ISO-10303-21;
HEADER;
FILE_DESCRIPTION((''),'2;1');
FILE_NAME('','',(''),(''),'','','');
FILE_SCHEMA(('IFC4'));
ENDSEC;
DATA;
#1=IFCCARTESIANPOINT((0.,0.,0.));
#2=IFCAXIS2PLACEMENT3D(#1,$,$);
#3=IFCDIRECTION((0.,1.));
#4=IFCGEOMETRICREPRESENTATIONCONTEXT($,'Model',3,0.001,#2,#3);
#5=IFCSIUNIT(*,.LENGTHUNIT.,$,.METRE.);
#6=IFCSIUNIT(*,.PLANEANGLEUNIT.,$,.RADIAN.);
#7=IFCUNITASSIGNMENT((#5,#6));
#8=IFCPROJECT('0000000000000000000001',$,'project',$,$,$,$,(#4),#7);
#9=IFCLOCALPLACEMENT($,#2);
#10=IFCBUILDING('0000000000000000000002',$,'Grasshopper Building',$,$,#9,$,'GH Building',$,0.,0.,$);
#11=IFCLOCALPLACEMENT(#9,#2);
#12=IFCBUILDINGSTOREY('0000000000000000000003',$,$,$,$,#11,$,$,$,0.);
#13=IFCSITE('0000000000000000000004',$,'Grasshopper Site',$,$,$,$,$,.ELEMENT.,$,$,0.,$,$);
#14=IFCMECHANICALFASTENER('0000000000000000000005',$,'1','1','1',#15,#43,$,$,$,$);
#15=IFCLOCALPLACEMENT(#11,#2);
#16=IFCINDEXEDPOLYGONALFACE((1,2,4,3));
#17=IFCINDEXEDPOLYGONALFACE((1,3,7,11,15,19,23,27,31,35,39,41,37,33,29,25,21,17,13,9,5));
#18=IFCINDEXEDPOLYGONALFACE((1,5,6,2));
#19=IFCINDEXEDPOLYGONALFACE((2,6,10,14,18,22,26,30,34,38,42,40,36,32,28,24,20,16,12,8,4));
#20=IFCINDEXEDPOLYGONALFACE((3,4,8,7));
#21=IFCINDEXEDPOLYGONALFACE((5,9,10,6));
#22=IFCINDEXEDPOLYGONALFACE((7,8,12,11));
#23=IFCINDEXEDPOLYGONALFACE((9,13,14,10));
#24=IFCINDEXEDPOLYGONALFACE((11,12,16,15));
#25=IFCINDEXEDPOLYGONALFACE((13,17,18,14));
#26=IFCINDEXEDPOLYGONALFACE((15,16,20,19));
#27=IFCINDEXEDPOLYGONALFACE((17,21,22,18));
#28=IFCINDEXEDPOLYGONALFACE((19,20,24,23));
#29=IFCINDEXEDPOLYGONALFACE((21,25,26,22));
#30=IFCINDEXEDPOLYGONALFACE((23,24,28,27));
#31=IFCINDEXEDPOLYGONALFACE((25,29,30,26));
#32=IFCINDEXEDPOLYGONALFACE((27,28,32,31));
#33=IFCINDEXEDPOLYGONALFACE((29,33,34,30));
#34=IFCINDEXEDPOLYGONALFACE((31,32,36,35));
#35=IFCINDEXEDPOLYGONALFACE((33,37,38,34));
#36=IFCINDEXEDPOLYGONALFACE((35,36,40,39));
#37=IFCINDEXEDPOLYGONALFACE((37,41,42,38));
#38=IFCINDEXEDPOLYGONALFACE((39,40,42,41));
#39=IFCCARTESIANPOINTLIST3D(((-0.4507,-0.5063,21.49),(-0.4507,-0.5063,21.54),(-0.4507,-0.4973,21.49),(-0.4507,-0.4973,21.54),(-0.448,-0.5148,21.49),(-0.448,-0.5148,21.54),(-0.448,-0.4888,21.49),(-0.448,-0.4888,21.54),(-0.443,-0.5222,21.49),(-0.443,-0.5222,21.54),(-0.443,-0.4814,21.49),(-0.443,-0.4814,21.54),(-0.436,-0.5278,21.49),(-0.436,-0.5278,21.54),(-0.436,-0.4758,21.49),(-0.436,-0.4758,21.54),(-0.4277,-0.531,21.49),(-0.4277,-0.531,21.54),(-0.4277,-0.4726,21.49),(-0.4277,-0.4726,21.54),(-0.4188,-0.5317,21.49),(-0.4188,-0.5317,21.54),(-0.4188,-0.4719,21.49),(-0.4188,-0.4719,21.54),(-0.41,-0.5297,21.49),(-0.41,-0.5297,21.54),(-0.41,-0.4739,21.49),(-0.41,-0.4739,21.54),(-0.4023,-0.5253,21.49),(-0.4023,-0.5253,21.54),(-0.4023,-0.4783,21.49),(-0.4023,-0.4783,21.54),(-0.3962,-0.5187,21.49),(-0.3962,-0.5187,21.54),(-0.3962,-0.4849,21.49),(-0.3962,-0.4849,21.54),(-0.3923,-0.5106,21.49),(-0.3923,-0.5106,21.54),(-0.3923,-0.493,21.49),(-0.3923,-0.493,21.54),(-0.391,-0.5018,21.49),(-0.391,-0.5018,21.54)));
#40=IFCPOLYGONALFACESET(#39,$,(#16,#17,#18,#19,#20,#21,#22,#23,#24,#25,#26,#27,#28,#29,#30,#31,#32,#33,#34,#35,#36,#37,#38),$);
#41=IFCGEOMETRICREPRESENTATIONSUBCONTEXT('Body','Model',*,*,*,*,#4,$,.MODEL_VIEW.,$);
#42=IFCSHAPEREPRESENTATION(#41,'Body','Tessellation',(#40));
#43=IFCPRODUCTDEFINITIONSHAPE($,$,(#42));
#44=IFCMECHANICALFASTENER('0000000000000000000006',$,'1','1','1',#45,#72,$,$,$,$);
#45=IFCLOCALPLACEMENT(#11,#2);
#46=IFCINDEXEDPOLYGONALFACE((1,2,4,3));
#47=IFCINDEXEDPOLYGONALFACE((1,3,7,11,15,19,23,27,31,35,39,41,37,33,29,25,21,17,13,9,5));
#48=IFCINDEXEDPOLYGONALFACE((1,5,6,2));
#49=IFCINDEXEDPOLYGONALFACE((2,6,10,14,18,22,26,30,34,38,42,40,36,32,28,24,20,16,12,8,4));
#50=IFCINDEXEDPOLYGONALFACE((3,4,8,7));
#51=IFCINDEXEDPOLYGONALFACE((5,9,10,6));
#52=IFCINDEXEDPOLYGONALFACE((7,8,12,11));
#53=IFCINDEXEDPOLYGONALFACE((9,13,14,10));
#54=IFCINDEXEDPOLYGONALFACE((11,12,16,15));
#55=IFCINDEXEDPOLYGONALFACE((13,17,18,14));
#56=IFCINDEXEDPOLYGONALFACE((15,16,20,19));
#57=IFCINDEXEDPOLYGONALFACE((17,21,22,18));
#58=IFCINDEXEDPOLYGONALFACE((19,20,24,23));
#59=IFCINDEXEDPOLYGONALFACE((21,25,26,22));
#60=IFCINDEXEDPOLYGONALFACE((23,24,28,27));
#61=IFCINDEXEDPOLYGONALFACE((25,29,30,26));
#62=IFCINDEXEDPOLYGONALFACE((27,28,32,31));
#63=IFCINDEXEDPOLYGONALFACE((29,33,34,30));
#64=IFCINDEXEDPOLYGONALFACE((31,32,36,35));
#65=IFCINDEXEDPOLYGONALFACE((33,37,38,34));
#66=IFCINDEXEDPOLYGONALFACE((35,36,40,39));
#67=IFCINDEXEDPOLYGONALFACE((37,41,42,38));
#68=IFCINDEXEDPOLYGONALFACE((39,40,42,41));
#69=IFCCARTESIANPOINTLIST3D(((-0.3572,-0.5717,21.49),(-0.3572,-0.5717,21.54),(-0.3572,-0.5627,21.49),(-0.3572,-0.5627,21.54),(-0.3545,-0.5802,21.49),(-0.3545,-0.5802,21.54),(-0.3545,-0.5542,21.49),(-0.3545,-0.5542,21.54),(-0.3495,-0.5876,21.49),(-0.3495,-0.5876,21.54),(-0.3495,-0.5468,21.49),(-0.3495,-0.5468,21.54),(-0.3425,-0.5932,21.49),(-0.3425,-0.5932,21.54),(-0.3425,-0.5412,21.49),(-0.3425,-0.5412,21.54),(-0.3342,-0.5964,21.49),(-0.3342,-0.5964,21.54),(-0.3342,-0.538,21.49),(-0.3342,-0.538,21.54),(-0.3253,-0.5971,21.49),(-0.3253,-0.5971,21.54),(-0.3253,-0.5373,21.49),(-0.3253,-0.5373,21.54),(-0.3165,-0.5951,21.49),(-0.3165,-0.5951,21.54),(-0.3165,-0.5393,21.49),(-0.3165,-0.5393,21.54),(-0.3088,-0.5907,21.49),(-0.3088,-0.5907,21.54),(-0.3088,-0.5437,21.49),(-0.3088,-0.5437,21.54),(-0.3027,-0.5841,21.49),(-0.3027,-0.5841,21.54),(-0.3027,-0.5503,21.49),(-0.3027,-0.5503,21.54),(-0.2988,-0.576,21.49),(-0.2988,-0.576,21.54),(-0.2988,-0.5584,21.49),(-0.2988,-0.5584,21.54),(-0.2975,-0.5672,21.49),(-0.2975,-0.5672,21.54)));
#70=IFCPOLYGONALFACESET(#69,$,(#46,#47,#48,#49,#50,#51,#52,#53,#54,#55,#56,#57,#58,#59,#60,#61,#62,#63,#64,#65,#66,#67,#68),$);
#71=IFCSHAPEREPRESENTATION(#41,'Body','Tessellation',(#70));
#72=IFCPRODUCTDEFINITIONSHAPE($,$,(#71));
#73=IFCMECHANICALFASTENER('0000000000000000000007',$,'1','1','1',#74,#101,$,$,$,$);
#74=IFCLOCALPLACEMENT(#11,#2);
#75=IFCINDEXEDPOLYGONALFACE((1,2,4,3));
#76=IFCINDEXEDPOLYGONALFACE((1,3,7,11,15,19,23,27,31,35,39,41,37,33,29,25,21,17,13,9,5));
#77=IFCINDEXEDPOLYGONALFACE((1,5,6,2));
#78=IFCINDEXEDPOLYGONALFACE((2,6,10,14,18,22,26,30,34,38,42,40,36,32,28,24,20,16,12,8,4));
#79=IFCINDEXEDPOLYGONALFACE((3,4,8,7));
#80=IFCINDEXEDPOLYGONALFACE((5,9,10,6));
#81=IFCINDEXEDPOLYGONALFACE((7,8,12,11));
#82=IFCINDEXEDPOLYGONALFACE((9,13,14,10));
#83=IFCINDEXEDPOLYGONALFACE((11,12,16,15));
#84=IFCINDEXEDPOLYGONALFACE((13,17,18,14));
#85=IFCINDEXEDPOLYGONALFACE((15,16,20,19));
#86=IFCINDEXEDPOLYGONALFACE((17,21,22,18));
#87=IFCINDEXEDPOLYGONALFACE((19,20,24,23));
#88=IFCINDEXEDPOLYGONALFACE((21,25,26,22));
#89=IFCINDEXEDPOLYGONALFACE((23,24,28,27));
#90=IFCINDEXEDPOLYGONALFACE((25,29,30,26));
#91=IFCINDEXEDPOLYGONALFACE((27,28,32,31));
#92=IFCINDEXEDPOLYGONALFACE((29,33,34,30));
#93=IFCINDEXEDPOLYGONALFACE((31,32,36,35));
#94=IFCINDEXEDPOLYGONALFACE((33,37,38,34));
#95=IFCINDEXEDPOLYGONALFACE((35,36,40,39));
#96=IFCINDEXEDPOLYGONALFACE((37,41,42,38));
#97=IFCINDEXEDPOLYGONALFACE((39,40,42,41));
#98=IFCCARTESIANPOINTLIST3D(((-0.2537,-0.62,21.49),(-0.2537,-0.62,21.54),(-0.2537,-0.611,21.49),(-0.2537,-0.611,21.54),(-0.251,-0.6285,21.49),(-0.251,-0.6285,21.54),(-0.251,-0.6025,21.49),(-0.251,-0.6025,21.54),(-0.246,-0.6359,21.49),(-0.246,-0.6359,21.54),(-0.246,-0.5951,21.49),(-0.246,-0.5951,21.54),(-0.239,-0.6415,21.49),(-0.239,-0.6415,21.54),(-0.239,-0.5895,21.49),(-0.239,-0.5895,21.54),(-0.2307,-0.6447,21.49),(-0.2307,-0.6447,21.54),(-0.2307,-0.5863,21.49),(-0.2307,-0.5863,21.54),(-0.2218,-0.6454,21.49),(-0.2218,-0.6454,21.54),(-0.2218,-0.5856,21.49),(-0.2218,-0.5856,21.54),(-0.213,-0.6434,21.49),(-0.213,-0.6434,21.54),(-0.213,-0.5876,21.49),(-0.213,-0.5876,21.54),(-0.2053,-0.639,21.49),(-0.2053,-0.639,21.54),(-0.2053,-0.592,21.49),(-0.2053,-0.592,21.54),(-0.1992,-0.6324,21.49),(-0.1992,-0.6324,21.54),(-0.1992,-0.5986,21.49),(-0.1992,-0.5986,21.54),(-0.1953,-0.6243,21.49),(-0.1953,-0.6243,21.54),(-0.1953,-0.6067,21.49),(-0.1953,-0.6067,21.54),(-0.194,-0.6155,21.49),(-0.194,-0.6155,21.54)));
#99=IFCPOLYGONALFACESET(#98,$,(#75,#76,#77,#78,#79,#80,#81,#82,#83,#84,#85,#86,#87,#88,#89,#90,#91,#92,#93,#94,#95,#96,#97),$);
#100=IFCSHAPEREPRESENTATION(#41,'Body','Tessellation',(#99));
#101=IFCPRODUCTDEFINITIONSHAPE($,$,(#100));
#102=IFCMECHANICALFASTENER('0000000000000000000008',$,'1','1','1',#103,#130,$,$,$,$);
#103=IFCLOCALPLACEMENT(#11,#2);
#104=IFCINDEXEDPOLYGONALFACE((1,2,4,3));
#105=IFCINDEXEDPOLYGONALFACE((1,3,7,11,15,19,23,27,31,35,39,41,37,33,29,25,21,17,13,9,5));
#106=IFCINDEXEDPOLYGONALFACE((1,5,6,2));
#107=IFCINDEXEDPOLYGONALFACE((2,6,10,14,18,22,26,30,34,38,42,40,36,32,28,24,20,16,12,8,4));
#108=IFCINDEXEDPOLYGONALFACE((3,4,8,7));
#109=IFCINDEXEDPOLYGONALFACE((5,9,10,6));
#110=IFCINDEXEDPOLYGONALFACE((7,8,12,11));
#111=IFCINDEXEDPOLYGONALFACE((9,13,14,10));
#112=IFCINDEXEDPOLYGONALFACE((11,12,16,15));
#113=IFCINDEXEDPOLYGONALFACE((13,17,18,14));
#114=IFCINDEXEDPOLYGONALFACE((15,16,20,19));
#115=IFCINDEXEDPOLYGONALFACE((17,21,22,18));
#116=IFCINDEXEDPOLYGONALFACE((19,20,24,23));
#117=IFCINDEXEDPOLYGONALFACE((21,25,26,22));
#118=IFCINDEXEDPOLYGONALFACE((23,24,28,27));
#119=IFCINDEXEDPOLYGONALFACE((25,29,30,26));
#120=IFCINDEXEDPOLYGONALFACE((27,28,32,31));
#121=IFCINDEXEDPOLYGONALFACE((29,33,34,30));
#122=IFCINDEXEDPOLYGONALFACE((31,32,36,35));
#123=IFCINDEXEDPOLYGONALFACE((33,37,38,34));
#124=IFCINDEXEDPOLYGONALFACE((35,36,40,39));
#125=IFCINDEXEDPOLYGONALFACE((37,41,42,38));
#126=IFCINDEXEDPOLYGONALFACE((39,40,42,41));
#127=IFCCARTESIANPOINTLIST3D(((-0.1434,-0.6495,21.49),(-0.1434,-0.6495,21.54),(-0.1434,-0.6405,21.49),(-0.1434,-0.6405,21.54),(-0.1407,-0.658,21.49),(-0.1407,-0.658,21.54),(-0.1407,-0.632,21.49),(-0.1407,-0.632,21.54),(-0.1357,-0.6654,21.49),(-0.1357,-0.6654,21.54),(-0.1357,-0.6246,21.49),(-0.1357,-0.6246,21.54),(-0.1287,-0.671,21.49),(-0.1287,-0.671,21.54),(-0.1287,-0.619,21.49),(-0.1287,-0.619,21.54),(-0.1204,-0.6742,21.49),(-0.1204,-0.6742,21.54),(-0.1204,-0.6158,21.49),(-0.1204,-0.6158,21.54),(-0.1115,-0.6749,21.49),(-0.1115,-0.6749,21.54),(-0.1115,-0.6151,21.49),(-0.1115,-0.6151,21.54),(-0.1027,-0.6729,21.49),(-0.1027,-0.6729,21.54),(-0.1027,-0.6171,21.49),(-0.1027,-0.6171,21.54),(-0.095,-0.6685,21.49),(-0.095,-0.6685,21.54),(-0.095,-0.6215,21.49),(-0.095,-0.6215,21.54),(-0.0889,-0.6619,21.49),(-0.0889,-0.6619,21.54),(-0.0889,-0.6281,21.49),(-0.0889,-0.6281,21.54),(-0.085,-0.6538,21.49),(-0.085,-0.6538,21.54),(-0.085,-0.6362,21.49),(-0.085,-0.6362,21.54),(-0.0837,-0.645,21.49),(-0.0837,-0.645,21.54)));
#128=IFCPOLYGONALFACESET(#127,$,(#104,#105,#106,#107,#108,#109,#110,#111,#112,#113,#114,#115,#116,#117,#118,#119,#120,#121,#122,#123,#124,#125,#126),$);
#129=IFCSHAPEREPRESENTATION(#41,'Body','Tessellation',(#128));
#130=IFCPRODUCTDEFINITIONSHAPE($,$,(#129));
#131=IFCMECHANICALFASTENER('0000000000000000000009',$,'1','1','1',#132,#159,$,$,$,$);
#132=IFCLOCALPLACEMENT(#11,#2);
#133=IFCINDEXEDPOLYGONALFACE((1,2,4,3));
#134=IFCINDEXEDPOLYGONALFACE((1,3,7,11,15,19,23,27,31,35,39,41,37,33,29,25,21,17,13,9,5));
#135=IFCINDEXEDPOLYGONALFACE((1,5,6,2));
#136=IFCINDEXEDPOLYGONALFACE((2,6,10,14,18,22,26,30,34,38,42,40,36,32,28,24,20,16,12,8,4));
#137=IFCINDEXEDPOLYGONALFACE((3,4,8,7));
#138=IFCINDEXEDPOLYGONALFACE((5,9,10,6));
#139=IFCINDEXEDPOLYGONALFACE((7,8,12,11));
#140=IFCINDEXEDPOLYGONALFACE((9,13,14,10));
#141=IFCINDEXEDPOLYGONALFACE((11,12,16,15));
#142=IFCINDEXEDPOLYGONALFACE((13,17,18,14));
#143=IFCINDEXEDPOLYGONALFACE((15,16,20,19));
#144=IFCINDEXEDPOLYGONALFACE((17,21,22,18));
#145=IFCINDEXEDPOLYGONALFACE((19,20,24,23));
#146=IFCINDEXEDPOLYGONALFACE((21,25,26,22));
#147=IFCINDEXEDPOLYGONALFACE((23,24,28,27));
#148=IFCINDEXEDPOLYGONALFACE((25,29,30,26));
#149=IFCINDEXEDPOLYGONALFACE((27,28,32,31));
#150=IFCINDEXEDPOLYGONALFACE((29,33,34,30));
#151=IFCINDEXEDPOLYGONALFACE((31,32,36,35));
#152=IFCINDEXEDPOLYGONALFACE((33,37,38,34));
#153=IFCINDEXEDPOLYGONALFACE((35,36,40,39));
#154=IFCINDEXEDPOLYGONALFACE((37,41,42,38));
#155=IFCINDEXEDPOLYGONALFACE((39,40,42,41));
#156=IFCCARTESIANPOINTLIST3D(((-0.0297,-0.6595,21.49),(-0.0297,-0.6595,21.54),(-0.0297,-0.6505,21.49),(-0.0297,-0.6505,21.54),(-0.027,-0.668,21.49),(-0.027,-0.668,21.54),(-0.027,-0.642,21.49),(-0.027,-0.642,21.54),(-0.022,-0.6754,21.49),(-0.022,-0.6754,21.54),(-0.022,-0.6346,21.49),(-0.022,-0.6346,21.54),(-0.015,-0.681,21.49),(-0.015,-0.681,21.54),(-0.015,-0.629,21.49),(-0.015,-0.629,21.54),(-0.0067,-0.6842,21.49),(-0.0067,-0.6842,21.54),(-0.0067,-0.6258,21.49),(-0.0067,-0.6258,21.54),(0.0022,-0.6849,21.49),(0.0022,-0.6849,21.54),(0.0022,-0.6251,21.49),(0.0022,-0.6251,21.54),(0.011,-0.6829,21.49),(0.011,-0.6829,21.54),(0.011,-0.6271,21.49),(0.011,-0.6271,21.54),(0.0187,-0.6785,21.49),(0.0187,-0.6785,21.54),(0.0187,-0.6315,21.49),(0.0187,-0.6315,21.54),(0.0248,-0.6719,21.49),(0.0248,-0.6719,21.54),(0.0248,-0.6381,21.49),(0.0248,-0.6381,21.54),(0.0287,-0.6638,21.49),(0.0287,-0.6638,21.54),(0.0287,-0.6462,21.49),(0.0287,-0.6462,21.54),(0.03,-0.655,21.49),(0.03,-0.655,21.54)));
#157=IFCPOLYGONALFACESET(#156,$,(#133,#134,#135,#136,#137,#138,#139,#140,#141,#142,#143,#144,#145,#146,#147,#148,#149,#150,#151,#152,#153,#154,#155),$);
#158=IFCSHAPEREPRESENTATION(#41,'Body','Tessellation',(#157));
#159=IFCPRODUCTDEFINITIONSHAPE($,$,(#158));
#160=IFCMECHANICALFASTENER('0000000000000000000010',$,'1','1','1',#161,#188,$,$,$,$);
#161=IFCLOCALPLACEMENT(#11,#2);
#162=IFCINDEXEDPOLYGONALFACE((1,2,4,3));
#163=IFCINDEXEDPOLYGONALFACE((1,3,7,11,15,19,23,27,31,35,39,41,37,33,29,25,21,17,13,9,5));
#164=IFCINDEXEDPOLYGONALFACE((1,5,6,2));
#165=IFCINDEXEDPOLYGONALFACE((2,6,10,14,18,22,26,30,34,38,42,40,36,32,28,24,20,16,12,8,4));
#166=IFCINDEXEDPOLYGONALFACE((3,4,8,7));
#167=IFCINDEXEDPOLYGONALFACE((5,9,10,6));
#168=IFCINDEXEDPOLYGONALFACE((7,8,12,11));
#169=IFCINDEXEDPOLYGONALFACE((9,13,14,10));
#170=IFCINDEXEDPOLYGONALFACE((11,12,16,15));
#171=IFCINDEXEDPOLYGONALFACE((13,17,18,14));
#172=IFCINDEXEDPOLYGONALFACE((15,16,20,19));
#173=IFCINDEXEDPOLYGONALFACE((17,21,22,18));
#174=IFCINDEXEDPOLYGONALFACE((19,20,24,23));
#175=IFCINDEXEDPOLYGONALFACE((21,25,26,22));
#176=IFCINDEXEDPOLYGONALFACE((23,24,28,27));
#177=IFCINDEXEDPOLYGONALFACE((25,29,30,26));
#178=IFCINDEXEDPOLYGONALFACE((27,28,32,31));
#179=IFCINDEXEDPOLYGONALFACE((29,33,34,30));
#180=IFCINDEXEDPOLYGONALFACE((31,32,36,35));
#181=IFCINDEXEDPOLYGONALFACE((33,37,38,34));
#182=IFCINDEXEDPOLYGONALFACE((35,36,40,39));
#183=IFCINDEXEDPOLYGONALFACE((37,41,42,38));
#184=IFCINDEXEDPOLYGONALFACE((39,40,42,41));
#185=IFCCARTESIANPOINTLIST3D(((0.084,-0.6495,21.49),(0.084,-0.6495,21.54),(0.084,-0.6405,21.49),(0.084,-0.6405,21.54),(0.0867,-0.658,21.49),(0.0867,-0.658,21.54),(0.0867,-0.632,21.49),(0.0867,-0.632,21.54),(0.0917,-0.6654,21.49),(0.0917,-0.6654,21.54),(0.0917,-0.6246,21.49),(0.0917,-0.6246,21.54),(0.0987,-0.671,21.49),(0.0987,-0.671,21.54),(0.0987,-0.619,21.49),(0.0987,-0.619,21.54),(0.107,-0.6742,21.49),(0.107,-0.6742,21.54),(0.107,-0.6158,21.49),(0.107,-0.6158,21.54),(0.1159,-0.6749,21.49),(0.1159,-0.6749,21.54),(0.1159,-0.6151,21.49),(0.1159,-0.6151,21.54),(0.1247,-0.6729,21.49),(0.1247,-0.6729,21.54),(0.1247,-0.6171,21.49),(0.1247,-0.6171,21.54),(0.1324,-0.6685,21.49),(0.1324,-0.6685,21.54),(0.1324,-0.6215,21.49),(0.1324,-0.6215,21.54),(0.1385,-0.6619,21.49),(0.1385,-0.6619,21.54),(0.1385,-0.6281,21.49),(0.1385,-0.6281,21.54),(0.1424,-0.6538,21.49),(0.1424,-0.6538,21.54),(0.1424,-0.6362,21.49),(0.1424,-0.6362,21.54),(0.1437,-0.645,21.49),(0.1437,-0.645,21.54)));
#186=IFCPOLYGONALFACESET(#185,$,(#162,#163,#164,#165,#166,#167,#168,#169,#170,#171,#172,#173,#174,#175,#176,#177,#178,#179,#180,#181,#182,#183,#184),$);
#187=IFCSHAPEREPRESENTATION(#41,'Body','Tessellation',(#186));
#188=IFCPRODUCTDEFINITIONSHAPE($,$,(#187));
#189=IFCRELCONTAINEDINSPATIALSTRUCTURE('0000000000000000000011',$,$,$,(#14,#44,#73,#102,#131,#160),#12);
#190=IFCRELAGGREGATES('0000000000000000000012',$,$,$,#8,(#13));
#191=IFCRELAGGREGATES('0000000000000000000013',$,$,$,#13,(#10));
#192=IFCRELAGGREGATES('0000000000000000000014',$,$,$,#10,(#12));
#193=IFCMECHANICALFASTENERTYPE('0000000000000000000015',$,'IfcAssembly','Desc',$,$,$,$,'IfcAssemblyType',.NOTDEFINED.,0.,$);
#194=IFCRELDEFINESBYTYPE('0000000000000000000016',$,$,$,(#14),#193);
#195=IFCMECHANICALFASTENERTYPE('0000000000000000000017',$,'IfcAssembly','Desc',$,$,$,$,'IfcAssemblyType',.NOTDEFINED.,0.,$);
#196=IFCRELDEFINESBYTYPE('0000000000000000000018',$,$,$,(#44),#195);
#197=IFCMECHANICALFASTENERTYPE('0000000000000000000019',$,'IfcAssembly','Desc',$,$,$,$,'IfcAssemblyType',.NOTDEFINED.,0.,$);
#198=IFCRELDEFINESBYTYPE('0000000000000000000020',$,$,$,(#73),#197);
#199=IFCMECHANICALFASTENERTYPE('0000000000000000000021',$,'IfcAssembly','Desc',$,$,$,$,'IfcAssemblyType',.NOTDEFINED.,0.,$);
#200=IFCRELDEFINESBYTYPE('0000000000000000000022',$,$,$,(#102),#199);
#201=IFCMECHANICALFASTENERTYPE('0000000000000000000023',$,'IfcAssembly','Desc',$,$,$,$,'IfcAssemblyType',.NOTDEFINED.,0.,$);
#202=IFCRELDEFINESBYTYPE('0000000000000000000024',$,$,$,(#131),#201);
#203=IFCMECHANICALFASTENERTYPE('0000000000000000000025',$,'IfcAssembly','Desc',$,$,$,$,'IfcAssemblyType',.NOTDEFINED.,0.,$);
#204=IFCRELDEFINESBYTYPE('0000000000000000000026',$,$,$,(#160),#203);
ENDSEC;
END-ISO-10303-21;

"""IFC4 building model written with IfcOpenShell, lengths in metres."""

from ifc_helpers import new_model, si_unit, direction, frame, origin, place, context, subcontext, project, spatial, circle, extrude, source, transform, mapped, type_object, type_shapes, element, save


model = new_model("IFC4")

# Units and contexts
model_context = context("Model", 3, precision=0.001, world=origin(), true_north=direction((0.0, 1.0)))
body_context = subcontext(model_context, "Body", "Model", "MODEL_VIEW")
ifc_project = project(units=[si_unit("LENGTHUNIT", "METRE"), si_unit("PLANEANGLEUNIT", "RADIAN")], contexts=[model_context])

# Site, building, storey
site = spatial("IfcSite", under=ifc_project, Name="Grasshopper Site", CompositionType="ELEMENT", RefElevation=0.0)
building_placement = place(None, origin())
building = spatial("IfcBuilding", under=site, at=building_placement, Name="Grasshopper Building", LongName="GH Building", ElevationOfRefHeight=0.0, ElevationOfTerrain=0.0)
storey_placement = place(building_placement, origin())
storey = spatial("IfcBuildingStorey", under=building, at=storey_placement, Elevation=0.0)

# Mechanical fasteners
mechanical_fastener_type_1 = type_object("IfcMechanicalFastenerType", Name="IfcAssembly", Description="Desc", ElementType="IfcAssemblyType", NominalDiameter=0.0)
shared_shape_1 = source(origin(), body_context, "Body", "SweptSolid", [
    extrude(circle(Radius=0.03), frame((-0.421, -0.5018, 21.54), z_axis=(0.0, 0.0, -1.0), x_axis=(1.0, 0.0, 0.0)), (0.0, 0.0, 1.0), 0.05),
])
type_shapes(mechanical_fastener_type_1, [shared_shape_1])
mechanical_fastener_1_placement = place(storey_placement, origin())
element("IfcMechanicalFastener", 1, at=mechanical_fastener_1_placement, inside=storey, type_object=mechanical_fastener_type_1, Name="1", Description="1", ObjectType="1", context=body_context, shape_type="MappedRepresentation", body=[
    mapped(shared_shape_1, transform((0.0, 0.0, 0.0), scale=1.0)),
])
mechanical_fastener_type_2 = type_object("IfcMechanicalFastenerType", Name="IfcAssembly", Description="Desc", ElementType="IfcAssemblyType", NominalDiameter=0.0)
shared_shape_2 = source(origin(), body_context, "Body", "SweptSolid", [
    extrude(circle(Radius=0.03), frame((-0.3275, -0.5672, 21.54), z_axis=(0.0, 0.0, -1.0), x_axis=(1.0, 0.0, 0.0)), (0.0, 0.0, 1.0), 0.05),
])
type_shapes(mechanical_fastener_type_2, [shared_shape_2])
mechanical_fastener_2_placement = place(storey_placement, origin())
element("IfcMechanicalFastener", 2, at=mechanical_fastener_2_placement, inside=storey, type_object=mechanical_fastener_type_2, Name="1", Description="1", ObjectType="1", context=body_context, shape_type="MappedRepresentation", body=[
    mapped(shared_shape_2, transform((0.0, 0.0, 0.0), scale=1.0)),
])
mechanical_fastener_type_3 = type_object("IfcMechanicalFastenerType", Name="IfcAssembly", Description="Desc", ElementType="IfcAssemblyType", NominalDiameter=0.0)
shared_shape_3 = source(origin(), body_context, "Body", "SweptSolid", [
    extrude(circle(Radius=0.03), frame((-0.224, -0.6155, 21.54), z_axis=(0.0, 0.0, -1.0), x_axis=(1.0, 0.0, 0.0)), (0.0, 0.0, 1.0), 0.05),
])
type_shapes(mechanical_fastener_type_3, [shared_shape_3])
mechanical_fastener_3_placement = place(storey_placement, origin())
element("IfcMechanicalFastener", 3, at=mechanical_fastener_3_placement, inside=storey, type_object=mechanical_fastener_type_3, Name="1", Description="1", ObjectType="1", context=body_context, shape_type="MappedRepresentation", body=[
    mapped(shared_shape_3, transform((0.0, 0.0, 0.0), scale=1.0)),
])
mechanical_fastener_type_4 = type_object("IfcMechanicalFastenerType", Name="IfcAssembly", Description="Desc", ElementType="IfcAssemblyType", NominalDiameter=0.0)
shared_shape_4 = source(origin(), body_context, "Body", "SweptSolid", [
    extrude(circle(Radius=0.03), frame((-0.1137, -0.645, 21.54), z_axis=(0.0, 0.0, -1.0), x_axis=(1.0, 0.0, 0.0)), (0.0, 0.0, 1.0), 0.05),
])
type_shapes(mechanical_fastener_type_4, [shared_shape_4])
mechanical_fastener_4_placement = place(storey_placement, origin())
element("IfcMechanicalFastener", 4, at=mechanical_fastener_4_placement, inside=storey, type_object=mechanical_fastener_type_4, Name="1", Description="1", ObjectType="1", context=body_context, shape_type="MappedRepresentation", body=[
    mapped(shared_shape_4, transform((0.0, 0.0, 0.0), scale=1.0)),
])
mechanical_fastener_type_5 = type_object("IfcMechanicalFastenerType", Name="IfcAssembly", Description="Desc", ElementType="IfcAssemblyType", NominalDiameter=0.0)
shared_shape_5 = source(origin(), body_context, "Body", "SweptSolid", [
    extrude(circle(Radius=0.03), frame((0.0, -0.655, 21.54), z_axis=(0.0, 0.0, -1.0), x_axis=(1.0, 0.0, 0.0)), (0.0, 0.0, 1.0), 0.05),
])
type_shapes(mechanical_fastener_type_5, [shared_shape_5])
mechanical_fastener_5_placement = place(storey_placement, origin())
element("IfcMechanicalFastener", 5, at=mechanical_fastener_5_placement, inside=storey, type_object=mechanical_fastener_type_5, Name="1", Description="1", ObjectType="1", context=body_context, shape_type="MappedRepresentation", body=[
    mapped(shared_shape_5, transform((0.0, 0.0, 0.0), scale=1.0)),
])
mechanical_fastener_type_6 = type_object("IfcMechanicalFastenerType", Name="IfcAssembly", Description="Desc", ElementType="IfcAssemblyType", NominalDiameter=0.0)
shared_shape_6 = source(origin(), body_context, "Body", "SweptSolid", [
    extrude(circle(Radius=0.03), frame((0.1137, -0.645, 21.54), z_axis=(0.0, 0.0, -1.0), x_axis=(1.0, 0.0, 0.0)), (0.0, 0.0, 1.0), 0.05),
])
type_shapes(mechanical_fastener_type_6, [shared_shape_6])
mechanical_fastener_6_placement = place(storey_placement, origin())
element("IfcMechanicalFastener", 6, at=mechanical_fastener_6_placement, inside=storey, type_object=mechanical_fastener_type_6, Name="1", Description="1", ObjectType="1", context=body_context, shape_type="MappedRepresentation", body=[
    mapped(shared_shape_6, transform((0.0, 0.0, 0.0), scale=1.0)),
])

save(model, "model.ifc")
